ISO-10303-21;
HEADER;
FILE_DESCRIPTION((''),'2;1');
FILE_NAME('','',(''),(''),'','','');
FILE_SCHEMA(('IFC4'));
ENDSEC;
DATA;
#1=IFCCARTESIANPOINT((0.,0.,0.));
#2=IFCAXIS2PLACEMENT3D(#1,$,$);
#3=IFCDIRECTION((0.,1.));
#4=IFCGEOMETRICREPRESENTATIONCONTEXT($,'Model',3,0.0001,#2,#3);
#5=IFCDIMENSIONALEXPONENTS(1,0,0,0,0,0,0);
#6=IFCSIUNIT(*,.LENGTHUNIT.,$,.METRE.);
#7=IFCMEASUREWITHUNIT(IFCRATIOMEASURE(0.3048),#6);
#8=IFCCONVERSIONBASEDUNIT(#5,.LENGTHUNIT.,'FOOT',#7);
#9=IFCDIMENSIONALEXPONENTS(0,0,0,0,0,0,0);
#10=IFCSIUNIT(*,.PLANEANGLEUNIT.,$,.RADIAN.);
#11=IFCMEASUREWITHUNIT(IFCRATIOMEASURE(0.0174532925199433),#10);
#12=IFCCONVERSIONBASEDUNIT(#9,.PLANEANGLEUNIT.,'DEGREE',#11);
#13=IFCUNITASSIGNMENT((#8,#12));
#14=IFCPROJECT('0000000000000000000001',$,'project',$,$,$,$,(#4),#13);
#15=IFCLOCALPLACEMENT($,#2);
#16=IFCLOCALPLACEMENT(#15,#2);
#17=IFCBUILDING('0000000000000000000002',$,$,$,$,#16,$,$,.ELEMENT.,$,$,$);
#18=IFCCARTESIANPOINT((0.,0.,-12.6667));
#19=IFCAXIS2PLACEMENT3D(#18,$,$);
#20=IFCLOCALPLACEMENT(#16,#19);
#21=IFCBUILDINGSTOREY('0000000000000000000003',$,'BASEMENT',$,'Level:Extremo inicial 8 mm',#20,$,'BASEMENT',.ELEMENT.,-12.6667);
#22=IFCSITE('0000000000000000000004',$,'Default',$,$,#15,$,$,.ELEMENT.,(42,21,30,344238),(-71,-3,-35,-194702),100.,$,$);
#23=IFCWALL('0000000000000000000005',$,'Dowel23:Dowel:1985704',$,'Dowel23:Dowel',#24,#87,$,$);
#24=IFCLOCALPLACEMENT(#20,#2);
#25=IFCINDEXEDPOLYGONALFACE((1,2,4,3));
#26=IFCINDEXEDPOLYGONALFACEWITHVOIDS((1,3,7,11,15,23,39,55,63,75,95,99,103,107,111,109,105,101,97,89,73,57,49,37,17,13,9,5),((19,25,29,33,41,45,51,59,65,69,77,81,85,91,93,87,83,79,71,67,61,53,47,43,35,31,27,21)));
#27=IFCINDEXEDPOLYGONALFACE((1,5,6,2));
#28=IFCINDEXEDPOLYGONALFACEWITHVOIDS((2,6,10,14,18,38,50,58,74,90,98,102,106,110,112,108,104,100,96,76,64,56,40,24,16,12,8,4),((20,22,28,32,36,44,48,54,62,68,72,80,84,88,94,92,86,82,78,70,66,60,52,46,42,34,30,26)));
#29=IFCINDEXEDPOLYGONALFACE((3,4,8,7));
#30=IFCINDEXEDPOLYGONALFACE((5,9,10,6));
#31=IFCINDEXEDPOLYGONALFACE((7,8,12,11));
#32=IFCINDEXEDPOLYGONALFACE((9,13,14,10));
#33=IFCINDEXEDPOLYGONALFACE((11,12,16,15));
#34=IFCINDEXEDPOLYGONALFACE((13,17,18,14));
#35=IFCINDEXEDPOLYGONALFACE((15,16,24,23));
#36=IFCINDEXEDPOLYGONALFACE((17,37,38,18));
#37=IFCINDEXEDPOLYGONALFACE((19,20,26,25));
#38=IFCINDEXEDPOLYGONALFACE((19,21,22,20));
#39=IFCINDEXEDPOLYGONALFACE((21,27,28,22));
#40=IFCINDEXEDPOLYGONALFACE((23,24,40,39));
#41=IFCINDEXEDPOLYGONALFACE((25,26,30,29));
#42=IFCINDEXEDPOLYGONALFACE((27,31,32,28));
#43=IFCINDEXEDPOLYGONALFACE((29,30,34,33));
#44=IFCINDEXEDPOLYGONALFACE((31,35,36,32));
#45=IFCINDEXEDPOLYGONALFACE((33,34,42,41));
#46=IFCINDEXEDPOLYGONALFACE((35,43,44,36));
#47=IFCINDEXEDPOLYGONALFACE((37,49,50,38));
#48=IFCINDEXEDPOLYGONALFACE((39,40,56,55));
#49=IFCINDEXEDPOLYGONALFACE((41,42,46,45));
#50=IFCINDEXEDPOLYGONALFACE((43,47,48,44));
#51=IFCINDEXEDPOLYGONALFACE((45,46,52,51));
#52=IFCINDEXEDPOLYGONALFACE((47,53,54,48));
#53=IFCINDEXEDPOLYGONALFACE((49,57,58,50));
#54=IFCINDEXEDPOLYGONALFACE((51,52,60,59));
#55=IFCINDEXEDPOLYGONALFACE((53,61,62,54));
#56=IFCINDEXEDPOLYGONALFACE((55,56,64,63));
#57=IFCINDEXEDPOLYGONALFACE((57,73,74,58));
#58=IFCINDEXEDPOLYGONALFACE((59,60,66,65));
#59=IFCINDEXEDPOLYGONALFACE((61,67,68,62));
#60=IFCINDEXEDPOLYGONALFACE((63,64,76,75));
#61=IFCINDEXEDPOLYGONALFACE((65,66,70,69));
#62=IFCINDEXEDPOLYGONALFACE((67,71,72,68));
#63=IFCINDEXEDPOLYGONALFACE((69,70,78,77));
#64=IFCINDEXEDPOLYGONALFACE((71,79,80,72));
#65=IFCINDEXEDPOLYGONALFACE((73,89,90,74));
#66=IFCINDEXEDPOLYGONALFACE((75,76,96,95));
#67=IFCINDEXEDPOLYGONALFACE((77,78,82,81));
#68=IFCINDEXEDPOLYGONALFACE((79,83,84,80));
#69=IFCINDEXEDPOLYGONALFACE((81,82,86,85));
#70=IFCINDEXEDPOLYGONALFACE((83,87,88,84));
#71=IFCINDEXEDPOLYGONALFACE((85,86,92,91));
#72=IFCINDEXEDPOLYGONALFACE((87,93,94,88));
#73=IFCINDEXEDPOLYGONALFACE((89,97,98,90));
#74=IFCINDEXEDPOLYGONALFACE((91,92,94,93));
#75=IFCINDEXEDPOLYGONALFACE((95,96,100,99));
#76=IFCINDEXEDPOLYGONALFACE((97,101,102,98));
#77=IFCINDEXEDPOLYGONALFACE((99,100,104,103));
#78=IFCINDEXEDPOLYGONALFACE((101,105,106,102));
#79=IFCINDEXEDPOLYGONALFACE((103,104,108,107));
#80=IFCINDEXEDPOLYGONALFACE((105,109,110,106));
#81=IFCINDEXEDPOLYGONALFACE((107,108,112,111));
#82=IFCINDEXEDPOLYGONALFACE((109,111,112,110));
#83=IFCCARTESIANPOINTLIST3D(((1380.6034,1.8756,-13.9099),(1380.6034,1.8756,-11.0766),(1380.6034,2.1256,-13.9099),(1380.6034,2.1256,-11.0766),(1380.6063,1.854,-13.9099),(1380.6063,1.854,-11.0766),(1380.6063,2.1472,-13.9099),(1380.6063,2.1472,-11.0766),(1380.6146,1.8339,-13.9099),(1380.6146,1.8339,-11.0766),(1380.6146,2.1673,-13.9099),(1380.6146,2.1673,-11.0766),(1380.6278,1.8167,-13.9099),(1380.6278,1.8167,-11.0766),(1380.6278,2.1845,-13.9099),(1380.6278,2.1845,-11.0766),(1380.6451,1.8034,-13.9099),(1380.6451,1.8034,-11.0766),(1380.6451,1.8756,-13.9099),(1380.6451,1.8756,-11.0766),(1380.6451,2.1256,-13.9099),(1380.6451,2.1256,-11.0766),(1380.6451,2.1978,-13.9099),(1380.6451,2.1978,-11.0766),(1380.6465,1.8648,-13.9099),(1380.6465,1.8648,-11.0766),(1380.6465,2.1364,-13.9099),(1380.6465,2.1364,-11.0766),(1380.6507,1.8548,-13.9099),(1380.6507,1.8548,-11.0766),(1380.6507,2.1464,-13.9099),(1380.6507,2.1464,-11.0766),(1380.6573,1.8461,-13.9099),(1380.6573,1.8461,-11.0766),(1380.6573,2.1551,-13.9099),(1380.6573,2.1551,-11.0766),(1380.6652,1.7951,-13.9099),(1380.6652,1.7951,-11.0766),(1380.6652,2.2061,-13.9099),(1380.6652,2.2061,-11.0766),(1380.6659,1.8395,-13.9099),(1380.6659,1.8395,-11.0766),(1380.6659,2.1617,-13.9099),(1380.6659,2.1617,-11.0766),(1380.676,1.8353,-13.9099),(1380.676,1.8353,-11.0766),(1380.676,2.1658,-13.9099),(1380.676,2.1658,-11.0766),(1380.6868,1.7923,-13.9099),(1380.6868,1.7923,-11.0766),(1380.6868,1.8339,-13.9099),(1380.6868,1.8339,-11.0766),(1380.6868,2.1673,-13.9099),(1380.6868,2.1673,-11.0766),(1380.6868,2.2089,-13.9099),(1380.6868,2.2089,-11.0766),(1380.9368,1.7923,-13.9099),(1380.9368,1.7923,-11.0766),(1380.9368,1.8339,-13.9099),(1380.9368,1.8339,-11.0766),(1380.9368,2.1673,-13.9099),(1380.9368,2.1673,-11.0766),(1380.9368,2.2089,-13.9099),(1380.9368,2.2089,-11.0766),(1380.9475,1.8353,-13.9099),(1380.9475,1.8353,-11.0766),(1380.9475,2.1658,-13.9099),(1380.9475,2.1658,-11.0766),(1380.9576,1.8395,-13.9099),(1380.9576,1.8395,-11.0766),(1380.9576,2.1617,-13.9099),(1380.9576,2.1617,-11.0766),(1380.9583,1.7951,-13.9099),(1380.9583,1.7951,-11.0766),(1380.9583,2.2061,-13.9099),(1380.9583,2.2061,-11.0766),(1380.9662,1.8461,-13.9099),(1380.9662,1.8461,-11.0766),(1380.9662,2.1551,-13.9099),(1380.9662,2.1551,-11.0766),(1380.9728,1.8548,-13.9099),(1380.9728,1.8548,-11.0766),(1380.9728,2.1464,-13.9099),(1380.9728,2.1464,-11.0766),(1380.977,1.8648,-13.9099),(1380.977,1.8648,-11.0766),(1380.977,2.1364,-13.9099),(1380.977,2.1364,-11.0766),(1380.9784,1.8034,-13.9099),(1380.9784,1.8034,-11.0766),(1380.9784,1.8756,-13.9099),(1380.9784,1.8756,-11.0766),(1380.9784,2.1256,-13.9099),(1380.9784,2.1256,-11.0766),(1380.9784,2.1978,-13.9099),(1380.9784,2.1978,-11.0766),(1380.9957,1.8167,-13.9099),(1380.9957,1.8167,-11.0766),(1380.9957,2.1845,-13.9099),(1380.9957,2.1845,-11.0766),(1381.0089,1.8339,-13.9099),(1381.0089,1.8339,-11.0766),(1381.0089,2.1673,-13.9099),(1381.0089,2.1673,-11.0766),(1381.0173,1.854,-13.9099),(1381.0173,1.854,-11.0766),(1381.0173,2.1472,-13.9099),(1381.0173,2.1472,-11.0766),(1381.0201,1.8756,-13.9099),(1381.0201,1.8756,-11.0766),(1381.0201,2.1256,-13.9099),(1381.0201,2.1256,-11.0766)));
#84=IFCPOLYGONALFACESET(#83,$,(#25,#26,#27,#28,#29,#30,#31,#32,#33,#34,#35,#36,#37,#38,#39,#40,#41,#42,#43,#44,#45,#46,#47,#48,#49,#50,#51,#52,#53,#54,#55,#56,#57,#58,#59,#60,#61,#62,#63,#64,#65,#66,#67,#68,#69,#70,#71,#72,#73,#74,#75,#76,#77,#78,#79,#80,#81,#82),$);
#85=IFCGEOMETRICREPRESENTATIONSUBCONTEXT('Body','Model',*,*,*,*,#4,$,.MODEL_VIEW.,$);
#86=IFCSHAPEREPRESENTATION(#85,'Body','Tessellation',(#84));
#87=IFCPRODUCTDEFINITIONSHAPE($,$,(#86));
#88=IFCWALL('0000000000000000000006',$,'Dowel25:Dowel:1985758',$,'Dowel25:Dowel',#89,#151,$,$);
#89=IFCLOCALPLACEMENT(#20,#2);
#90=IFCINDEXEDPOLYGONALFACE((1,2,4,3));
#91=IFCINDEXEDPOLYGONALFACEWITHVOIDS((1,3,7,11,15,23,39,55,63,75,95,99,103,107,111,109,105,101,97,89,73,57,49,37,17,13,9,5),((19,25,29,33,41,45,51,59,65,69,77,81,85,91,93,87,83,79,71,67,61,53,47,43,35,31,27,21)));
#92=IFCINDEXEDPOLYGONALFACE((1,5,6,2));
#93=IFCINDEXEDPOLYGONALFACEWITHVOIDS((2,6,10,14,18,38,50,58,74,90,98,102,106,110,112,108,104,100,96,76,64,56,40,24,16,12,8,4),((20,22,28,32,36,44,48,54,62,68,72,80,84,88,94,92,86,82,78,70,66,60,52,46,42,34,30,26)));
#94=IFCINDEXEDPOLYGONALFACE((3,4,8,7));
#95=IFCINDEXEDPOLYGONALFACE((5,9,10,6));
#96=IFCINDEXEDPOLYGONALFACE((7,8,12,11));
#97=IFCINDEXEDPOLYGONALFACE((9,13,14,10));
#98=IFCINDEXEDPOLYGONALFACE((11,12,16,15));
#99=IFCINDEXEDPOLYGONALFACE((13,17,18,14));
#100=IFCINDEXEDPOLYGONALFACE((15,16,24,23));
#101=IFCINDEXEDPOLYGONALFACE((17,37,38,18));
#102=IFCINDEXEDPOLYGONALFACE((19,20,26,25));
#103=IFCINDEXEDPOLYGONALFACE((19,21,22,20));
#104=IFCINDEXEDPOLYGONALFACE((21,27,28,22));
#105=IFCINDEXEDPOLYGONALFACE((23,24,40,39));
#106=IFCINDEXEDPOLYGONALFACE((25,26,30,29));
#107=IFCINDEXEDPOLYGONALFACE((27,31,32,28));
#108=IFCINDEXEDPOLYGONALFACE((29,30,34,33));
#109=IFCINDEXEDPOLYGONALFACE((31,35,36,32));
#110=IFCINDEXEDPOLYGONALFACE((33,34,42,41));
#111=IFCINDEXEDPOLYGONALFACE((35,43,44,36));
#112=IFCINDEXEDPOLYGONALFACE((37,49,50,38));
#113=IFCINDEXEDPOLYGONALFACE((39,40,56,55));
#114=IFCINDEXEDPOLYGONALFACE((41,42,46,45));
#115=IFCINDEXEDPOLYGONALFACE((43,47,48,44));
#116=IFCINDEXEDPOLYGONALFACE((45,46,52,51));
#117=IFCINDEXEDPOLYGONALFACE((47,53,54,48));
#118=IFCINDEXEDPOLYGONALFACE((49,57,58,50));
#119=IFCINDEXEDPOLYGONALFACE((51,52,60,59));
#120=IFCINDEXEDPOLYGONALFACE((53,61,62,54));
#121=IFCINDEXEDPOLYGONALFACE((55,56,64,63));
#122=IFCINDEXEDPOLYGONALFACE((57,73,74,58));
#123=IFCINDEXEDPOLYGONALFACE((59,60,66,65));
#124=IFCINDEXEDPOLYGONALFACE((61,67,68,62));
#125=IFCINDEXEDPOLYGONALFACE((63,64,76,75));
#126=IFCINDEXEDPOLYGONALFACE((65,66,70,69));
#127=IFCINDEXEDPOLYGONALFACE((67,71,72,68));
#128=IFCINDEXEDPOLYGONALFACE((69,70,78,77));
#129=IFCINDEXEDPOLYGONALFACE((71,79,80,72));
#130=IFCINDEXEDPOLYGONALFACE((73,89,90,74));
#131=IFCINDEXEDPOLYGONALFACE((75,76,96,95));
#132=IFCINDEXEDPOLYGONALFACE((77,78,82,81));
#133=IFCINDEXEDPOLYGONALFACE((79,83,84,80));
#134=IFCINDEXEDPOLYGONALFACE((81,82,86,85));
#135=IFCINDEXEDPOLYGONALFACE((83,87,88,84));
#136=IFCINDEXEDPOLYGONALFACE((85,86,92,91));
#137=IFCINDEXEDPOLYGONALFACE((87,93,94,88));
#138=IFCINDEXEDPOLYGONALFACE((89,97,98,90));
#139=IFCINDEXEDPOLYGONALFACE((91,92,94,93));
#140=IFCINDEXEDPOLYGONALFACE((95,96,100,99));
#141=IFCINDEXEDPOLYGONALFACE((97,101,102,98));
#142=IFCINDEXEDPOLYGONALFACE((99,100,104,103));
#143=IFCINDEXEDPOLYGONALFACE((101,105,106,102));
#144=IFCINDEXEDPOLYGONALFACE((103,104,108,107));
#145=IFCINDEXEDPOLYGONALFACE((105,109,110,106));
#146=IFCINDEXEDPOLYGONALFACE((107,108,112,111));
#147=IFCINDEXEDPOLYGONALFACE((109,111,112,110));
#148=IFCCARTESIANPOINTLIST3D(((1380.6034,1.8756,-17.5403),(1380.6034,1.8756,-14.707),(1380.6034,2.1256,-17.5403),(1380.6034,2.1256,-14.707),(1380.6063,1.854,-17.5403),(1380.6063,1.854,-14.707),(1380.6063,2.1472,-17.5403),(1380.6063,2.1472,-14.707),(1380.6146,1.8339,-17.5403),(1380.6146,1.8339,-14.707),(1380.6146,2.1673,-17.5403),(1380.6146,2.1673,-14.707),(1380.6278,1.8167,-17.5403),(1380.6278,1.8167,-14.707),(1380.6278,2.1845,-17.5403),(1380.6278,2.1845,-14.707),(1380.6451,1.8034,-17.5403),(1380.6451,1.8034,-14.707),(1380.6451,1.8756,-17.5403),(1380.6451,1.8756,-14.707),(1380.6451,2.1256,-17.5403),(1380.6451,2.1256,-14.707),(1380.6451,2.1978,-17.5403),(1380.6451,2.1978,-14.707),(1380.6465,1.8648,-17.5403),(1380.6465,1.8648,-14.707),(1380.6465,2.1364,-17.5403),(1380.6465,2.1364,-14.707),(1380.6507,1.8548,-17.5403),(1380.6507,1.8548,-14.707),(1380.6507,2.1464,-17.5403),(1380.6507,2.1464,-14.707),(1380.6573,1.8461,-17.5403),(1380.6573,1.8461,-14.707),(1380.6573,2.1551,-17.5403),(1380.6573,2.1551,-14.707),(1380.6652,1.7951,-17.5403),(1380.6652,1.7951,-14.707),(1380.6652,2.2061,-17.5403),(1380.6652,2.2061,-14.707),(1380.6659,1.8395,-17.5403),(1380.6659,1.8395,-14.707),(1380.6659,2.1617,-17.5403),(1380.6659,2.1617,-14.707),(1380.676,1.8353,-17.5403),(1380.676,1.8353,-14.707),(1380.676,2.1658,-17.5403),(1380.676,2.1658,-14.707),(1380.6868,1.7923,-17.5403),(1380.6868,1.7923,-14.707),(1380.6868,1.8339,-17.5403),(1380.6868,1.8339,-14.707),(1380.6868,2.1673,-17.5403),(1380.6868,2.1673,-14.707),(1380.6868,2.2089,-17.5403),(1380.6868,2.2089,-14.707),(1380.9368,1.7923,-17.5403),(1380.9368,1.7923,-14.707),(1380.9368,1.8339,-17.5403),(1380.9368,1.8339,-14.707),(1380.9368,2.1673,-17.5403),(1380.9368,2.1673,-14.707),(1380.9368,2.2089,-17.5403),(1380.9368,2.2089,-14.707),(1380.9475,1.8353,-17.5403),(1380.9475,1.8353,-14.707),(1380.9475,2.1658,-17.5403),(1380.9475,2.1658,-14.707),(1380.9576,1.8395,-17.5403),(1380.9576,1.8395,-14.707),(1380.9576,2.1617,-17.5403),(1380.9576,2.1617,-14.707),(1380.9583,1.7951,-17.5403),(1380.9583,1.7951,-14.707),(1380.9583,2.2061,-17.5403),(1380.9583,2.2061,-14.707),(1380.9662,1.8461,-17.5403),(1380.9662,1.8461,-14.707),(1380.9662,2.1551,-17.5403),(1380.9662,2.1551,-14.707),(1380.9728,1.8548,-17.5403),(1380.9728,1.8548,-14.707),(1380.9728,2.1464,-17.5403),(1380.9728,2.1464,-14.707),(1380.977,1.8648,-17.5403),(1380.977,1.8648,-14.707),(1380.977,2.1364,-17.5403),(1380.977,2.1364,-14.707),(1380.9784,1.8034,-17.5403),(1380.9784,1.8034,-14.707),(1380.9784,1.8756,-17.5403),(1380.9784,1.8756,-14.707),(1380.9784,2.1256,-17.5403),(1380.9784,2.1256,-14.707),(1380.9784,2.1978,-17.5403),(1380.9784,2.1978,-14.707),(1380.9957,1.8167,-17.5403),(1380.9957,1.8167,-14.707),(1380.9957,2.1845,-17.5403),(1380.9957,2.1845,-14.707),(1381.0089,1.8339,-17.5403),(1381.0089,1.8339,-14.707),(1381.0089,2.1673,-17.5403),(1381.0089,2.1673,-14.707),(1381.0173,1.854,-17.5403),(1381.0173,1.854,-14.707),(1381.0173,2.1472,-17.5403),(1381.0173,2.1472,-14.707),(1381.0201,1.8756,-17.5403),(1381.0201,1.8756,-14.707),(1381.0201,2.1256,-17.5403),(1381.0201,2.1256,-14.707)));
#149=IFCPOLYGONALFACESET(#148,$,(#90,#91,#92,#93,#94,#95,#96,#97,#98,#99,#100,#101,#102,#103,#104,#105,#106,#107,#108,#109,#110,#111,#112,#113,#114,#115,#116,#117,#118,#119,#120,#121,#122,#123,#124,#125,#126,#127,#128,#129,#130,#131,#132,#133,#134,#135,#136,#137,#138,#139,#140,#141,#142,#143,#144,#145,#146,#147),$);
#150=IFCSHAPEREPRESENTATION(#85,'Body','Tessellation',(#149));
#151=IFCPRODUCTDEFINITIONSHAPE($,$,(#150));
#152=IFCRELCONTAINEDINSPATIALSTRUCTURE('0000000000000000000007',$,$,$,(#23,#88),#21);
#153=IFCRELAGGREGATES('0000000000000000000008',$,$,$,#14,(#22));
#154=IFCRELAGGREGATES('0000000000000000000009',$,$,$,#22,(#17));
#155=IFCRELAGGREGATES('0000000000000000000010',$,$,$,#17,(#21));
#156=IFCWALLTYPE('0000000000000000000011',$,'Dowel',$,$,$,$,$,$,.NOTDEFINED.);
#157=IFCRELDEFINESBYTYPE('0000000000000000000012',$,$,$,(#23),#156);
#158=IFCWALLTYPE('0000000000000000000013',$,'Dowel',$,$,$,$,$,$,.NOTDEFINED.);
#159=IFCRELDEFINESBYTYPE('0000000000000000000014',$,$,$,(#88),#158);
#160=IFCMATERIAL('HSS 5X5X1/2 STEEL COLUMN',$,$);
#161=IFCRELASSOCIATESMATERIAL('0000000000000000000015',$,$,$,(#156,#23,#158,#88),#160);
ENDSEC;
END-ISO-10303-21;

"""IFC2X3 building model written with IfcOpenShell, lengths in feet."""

from ifc_helpers import new_model, entity, si_unit, converted_unit, direction, frame, frame_2d, origin, place, context, subcontext, project, spatial, polyline, circle_curve, parameter, trimmed, segment, composite_curve, outline, extrude, material, type_object, element, save


model = new_model("IFC2X3")

# Units and contexts
model_context = context("Model", 3, precision=0.0001, world=origin(), true_north=direction((0.0, 1.0)))
body_context = subcontext(model_context, "Body", "Model", "MODEL_VIEW")
ifc_project = project(units=[converted_unit("LENGTHUNIT", "FOOT", entity("IfcRatioMeasure", 0.3048), si_unit("LENGTHUNIT", "METRE"), dimensions=[1, 0, 0, 0, 0, 0, 0]), converted_unit("PLANEANGLEUNIT", "DEGREE", entity("IfcRatioMeasure", 0.0174532925199433), si_unit("PLANEANGLEUNIT", "RADIAN"), dimensions=[0, 0, 0, 0, 0, 0, 0])], contexts=[model_context])

# Site, building, storey
site_placement = place(None, origin())
site = spatial("IfcSite", under=ifc_project, at=site_placement, Name="Default", CompositionType="ELEMENT", RefLatitude=(42, 21, 30, 344238), RefLongitude=(-71, -3, -35, -194702), RefElevation=100.0)
building_placement = place(site_placement, origin())
building = spatial("IfcBuilding", under=site, at=building_placement, CompositionType="ELEMENT")
storey_placement = place(building_placement, frame((0.0, 0.0, -12.6667)))
storey = spatial("IfcBuildingStorey", under=building, at=storey_placement, Name="BASEMENT", ObjectType="Level:Extremo inicial 8 mm", LongName="BASEMENT", CompositionType="ELEMENT", Elevation=-12.6667)

# Walls, openings
ifc_material_1 = material(Name="HSS 5X5X1/2 STEEL COLUMN")
wall_type_1 = type_object("IfcWallType", Name="Dowel", PredefinedType="NOTDEFINED", material=ifc_material_1)
wall_1_placement = place(storey_placement, frame((1380.6034, 1.7923, -13.9099)))
wall_1 = element("IfcWall", 1, at=wall_1_placement, inside=storey, type_object=wall_type_1, material=ifc_material_1, Name="Dowel23:Dowel:1985704", ObjectType="Dowel23:Dowel", context=body_context, shape_type="SweptSolid", body=[
    extrude(outline(composite_curve([segment(polyline([(-0.125, -0.2083), (0.125, -0.2083)]), True, "CONTINUOUS"), segment(trimmed(circle_curve(frame_2d((0.125, -0.125), x_axis=(0.0, 1.0)), 0.0833), [parameter(180.0)], [parameter(270.0)], True, "PARAMETER"), True, "CONTINUOUS"), segment(polyline([(0.2083, -0.125), (0.2083, 0.125)]), True, "CONTINUOUS"), segment(trimmed(circle_curve(frame_2d((0.125, 0.125), x_axis=(0.0, 1.0)), 0.0833), [parameter(270.0)], [parameter(0.0)], True, "PARAMETER"), True, "CONTINUOUS"), segment(polyline([(0.125, 0.2083), (-0.125, 0.2083)]), True, "CONTINUOUS"), segment(trimmed(circle_curve(frame_2d((-0.125, 0.125), x_axis=(0.0, 1.0)), 0.0833), [parameter(360.0)], [parameter(90.0)], True, "PARAMETER"), True, "CONTINUOUS"), segment(polyline([(-0.2083, 0.125), (-0.2083, -0.125)]), True, "CONTINUOUS"), segment(trimmed(circle_curve(frame_2d((-0.125, -0.125), x_axis=(0.0, 1.0)), 0.0833), [parameter(90.0)], [parameter(180.0)], True, "PARAMETER"), True, "CONTINUOUS")], self_intersect=False)), frame((0.2083, 0.2083, 0.0), z_axis=(0.0, 0.0, 1.0), x_axis=(0.0, 1.0, 0.0)), (0.0, 0.0, 1.0), 2.8333),
])
opening_1_placement = place(storey_placement, frame((1380.6034, 1.7923, -13.9099)))
element("IfcOpeningElement", 2, at=opening_1_placement, cuts=wall_1, ObjectType="Opening", context=body_context, shape_type="SweptSolid", body=[
    extrude(outline(composite_curve([segment(polyline([(-0.125, -0.1667), (0.125, -0.1667)]), True, "CONTINUOUS"), segment(trimmed(circle_curve(frame_2d((0.125, -0.125), x_axis=(0.0, 1.0)), 0.0417), [parameter(180.0)], [parameter(270.0)], True, "PARAMETER"), True, "CONTINUOUS"), segment(polyline([(0.1667, -0.125), (0.1667, 0.125)]), True, "CONTINUOUS"), segment(trimmed(circle_curve(frame_2d((0.125, 0.125), x_axis=(0.0, 1.0)), 0.0417), [parameter(270.0)], [parameter(360.0)], True, "PARAMETER"), True, "CONTINUOUS"), segment(polyline([(0.125, 0.1667), (-0.125, 0.1667)]), True, "CONTINUOUS"), segment(trimmed(circle_curve(frame_2d((-0.125, 0.125), x_axis=(0.0, 1.0)), 0.0417), [parameter(0.0)], [parameter(90.0)], True, "PARAMETER"), True, "CONTINUOUS"), segment(polyline([(-0.1667, 0.125), (-0.1667, -0.125)]), True, "CONTINUOUS"), segment(trimmed(circle_curve(frame_2d((-0.125, -0.125), x_axis=(0.0, 1.0)), 0.0417), [parameter(90.0)], [parameter(180.0)], True, "PARAMETER"), True, "CONTINUOUS")], self_intersect=False)), frame((0.2083, 0.2083, 0.0), z_axis=(0.0, 0.0, 1.0), x_axis=(0.0, 1.0, 0.0)), (0.0, 0.0, 1.0), 2.8333),
])
wall_type_2 = type_object("IfcWallType", Name="Dowel", PredefinedType="NOTDEFINED", material=ifc_material_1)
wall_2_placement = place(storey_placement, frame((1380.6034, 1.7923, -17.5403)))
wall_2 = element("IfcWall", 3, at=wall_2_placement, inside=storey, type_object=wall_type_2, material=ifc_material_1, Name="Dowel25:Dowel:1985758", ObjectType="Dowel25:Dowel", context=body_context, shape_type="SweptSolid", body=[
    extrude(outline(composite_curve([segment(polyline([(-0.125, -0.2083), (0.125, -0.2083)]), True, "CONTINUOUS"), segment(trimmed(circle_curve(frame_2d((0.125, -0.125), x_axis=(0.0, 1.0)), 0.0833), [parameter(180.0)], [parameter(270.0)], True, "PARAMETER"), True, "CONTINUOUS"), segment(polyline([(0.2083, -0.125), (0.2083, 0.125)]), True, "CONTINUOUS"), segment(trimmed(circle_curve(frame_2d((0.125, 0.125), x_axis=(0.0, 1.0)), 0.0833), [parameter(270.0)], [parameter(0.0)], True, "PARAMETER"), True, "CONTINUOUS"), segment(polyline([(0.125, 0.2083), (-0.125, 0.2083)]), True, "CONTINUOUS"), segment(trimmed(circle_curve(frame_2d((-0.125, 0.125), x_axis=(0.0, 1.0)), 0.0833), [parameter(360.0)], [parameter(90.0)], True, "PARAMETER"), True, "CONTINUOUS"), segment(polyline([(-0.2083, 0.125), (-0.2083, -0.125)]), True, "CONTINUOUS"), segment(trimmed(circle_curve(frame_2d((-0.125, -0.125), x_axis=(0.0, 1.0)), 0.0833), [parameter(90.0)], [parameter(180.0)], True, "PARAMETER"), True, "CONTINUOUS")], self_intersect=False)), frame((0.2083, 0.2083, 0.0), z_axis=(0.0, 0.0, 1.0), x_axis=(0.0, 1.0, 0.0)), (0.0, 0.0, 1.0), 2.8333),
])
opening_2_placement = place(storey_placement, frame((1380.6034, 1.7923, -17.5403)))
element("IfcOpeningElement", 4, at=opening_2_placement, cuts=wall_2, ObjectType="Opening", context=body_context, shape_type="SweptSolid", body=[
    extrude(outline(composite_curve([segment(polyline([(-0.125, -0.1667), (0.125, -0.1667)]), True, "CONTINUOUS"), segment(trimmed(circle_curve(frame_2d((0.125, -0.125), x_axis=(0.0, 1.0)), 0.0417), [parameter(180.0)], [parameter(270.0)], True, "PARAMETER"), True, "CONTINUOUS"), segment(polyline([(0.1667, -0.125), (0.1667, 0.125)]), True, "CONTINUOUS"), segment(trimmed(circle_curve(frame_2d((0.125, 0.125), x_axis=(0.0, 1.0)), 0.0417), [parameter(270.0)], [parameter(360.0)], True, "PARAMETER"), True, "CONTINUOUS"), segment(polyline([(0.125, 0.1667), (-0.125, 0.1667)]), True, "CONTINUOUS"), segment(trimmed(circle_curve(frame_2d((-0.125, 0.125), x_axis=(0.0, 1.0)), 0.0417), [parameter(0.0)], [parameter(90.0)], True, "PARAMETER"), True, "CONTINUOUS"), segment(polyline([(-0.1667, 0.125), (-0.1667, -0.125)]), True, "CONTINUOUS"), segment(trimmed(circle_curve(frame_2d((-0.125, -0.125), x_axis=(0.0, 1.0)), 0.0417), [parameter(90.0)], [parameter(180.0)], True, "PARAMETER"), True, "CONTINUOUS")], self_intersect=False)), frame((0.2083, 0.2083, 0.0), z_axis=(0.0, 0.0, 1.0), x_axis=(0.0, 1.0, 0.0)), (0.0, 0.0, 1.0), 2.8333),
])

save(model, "model.ifc")
